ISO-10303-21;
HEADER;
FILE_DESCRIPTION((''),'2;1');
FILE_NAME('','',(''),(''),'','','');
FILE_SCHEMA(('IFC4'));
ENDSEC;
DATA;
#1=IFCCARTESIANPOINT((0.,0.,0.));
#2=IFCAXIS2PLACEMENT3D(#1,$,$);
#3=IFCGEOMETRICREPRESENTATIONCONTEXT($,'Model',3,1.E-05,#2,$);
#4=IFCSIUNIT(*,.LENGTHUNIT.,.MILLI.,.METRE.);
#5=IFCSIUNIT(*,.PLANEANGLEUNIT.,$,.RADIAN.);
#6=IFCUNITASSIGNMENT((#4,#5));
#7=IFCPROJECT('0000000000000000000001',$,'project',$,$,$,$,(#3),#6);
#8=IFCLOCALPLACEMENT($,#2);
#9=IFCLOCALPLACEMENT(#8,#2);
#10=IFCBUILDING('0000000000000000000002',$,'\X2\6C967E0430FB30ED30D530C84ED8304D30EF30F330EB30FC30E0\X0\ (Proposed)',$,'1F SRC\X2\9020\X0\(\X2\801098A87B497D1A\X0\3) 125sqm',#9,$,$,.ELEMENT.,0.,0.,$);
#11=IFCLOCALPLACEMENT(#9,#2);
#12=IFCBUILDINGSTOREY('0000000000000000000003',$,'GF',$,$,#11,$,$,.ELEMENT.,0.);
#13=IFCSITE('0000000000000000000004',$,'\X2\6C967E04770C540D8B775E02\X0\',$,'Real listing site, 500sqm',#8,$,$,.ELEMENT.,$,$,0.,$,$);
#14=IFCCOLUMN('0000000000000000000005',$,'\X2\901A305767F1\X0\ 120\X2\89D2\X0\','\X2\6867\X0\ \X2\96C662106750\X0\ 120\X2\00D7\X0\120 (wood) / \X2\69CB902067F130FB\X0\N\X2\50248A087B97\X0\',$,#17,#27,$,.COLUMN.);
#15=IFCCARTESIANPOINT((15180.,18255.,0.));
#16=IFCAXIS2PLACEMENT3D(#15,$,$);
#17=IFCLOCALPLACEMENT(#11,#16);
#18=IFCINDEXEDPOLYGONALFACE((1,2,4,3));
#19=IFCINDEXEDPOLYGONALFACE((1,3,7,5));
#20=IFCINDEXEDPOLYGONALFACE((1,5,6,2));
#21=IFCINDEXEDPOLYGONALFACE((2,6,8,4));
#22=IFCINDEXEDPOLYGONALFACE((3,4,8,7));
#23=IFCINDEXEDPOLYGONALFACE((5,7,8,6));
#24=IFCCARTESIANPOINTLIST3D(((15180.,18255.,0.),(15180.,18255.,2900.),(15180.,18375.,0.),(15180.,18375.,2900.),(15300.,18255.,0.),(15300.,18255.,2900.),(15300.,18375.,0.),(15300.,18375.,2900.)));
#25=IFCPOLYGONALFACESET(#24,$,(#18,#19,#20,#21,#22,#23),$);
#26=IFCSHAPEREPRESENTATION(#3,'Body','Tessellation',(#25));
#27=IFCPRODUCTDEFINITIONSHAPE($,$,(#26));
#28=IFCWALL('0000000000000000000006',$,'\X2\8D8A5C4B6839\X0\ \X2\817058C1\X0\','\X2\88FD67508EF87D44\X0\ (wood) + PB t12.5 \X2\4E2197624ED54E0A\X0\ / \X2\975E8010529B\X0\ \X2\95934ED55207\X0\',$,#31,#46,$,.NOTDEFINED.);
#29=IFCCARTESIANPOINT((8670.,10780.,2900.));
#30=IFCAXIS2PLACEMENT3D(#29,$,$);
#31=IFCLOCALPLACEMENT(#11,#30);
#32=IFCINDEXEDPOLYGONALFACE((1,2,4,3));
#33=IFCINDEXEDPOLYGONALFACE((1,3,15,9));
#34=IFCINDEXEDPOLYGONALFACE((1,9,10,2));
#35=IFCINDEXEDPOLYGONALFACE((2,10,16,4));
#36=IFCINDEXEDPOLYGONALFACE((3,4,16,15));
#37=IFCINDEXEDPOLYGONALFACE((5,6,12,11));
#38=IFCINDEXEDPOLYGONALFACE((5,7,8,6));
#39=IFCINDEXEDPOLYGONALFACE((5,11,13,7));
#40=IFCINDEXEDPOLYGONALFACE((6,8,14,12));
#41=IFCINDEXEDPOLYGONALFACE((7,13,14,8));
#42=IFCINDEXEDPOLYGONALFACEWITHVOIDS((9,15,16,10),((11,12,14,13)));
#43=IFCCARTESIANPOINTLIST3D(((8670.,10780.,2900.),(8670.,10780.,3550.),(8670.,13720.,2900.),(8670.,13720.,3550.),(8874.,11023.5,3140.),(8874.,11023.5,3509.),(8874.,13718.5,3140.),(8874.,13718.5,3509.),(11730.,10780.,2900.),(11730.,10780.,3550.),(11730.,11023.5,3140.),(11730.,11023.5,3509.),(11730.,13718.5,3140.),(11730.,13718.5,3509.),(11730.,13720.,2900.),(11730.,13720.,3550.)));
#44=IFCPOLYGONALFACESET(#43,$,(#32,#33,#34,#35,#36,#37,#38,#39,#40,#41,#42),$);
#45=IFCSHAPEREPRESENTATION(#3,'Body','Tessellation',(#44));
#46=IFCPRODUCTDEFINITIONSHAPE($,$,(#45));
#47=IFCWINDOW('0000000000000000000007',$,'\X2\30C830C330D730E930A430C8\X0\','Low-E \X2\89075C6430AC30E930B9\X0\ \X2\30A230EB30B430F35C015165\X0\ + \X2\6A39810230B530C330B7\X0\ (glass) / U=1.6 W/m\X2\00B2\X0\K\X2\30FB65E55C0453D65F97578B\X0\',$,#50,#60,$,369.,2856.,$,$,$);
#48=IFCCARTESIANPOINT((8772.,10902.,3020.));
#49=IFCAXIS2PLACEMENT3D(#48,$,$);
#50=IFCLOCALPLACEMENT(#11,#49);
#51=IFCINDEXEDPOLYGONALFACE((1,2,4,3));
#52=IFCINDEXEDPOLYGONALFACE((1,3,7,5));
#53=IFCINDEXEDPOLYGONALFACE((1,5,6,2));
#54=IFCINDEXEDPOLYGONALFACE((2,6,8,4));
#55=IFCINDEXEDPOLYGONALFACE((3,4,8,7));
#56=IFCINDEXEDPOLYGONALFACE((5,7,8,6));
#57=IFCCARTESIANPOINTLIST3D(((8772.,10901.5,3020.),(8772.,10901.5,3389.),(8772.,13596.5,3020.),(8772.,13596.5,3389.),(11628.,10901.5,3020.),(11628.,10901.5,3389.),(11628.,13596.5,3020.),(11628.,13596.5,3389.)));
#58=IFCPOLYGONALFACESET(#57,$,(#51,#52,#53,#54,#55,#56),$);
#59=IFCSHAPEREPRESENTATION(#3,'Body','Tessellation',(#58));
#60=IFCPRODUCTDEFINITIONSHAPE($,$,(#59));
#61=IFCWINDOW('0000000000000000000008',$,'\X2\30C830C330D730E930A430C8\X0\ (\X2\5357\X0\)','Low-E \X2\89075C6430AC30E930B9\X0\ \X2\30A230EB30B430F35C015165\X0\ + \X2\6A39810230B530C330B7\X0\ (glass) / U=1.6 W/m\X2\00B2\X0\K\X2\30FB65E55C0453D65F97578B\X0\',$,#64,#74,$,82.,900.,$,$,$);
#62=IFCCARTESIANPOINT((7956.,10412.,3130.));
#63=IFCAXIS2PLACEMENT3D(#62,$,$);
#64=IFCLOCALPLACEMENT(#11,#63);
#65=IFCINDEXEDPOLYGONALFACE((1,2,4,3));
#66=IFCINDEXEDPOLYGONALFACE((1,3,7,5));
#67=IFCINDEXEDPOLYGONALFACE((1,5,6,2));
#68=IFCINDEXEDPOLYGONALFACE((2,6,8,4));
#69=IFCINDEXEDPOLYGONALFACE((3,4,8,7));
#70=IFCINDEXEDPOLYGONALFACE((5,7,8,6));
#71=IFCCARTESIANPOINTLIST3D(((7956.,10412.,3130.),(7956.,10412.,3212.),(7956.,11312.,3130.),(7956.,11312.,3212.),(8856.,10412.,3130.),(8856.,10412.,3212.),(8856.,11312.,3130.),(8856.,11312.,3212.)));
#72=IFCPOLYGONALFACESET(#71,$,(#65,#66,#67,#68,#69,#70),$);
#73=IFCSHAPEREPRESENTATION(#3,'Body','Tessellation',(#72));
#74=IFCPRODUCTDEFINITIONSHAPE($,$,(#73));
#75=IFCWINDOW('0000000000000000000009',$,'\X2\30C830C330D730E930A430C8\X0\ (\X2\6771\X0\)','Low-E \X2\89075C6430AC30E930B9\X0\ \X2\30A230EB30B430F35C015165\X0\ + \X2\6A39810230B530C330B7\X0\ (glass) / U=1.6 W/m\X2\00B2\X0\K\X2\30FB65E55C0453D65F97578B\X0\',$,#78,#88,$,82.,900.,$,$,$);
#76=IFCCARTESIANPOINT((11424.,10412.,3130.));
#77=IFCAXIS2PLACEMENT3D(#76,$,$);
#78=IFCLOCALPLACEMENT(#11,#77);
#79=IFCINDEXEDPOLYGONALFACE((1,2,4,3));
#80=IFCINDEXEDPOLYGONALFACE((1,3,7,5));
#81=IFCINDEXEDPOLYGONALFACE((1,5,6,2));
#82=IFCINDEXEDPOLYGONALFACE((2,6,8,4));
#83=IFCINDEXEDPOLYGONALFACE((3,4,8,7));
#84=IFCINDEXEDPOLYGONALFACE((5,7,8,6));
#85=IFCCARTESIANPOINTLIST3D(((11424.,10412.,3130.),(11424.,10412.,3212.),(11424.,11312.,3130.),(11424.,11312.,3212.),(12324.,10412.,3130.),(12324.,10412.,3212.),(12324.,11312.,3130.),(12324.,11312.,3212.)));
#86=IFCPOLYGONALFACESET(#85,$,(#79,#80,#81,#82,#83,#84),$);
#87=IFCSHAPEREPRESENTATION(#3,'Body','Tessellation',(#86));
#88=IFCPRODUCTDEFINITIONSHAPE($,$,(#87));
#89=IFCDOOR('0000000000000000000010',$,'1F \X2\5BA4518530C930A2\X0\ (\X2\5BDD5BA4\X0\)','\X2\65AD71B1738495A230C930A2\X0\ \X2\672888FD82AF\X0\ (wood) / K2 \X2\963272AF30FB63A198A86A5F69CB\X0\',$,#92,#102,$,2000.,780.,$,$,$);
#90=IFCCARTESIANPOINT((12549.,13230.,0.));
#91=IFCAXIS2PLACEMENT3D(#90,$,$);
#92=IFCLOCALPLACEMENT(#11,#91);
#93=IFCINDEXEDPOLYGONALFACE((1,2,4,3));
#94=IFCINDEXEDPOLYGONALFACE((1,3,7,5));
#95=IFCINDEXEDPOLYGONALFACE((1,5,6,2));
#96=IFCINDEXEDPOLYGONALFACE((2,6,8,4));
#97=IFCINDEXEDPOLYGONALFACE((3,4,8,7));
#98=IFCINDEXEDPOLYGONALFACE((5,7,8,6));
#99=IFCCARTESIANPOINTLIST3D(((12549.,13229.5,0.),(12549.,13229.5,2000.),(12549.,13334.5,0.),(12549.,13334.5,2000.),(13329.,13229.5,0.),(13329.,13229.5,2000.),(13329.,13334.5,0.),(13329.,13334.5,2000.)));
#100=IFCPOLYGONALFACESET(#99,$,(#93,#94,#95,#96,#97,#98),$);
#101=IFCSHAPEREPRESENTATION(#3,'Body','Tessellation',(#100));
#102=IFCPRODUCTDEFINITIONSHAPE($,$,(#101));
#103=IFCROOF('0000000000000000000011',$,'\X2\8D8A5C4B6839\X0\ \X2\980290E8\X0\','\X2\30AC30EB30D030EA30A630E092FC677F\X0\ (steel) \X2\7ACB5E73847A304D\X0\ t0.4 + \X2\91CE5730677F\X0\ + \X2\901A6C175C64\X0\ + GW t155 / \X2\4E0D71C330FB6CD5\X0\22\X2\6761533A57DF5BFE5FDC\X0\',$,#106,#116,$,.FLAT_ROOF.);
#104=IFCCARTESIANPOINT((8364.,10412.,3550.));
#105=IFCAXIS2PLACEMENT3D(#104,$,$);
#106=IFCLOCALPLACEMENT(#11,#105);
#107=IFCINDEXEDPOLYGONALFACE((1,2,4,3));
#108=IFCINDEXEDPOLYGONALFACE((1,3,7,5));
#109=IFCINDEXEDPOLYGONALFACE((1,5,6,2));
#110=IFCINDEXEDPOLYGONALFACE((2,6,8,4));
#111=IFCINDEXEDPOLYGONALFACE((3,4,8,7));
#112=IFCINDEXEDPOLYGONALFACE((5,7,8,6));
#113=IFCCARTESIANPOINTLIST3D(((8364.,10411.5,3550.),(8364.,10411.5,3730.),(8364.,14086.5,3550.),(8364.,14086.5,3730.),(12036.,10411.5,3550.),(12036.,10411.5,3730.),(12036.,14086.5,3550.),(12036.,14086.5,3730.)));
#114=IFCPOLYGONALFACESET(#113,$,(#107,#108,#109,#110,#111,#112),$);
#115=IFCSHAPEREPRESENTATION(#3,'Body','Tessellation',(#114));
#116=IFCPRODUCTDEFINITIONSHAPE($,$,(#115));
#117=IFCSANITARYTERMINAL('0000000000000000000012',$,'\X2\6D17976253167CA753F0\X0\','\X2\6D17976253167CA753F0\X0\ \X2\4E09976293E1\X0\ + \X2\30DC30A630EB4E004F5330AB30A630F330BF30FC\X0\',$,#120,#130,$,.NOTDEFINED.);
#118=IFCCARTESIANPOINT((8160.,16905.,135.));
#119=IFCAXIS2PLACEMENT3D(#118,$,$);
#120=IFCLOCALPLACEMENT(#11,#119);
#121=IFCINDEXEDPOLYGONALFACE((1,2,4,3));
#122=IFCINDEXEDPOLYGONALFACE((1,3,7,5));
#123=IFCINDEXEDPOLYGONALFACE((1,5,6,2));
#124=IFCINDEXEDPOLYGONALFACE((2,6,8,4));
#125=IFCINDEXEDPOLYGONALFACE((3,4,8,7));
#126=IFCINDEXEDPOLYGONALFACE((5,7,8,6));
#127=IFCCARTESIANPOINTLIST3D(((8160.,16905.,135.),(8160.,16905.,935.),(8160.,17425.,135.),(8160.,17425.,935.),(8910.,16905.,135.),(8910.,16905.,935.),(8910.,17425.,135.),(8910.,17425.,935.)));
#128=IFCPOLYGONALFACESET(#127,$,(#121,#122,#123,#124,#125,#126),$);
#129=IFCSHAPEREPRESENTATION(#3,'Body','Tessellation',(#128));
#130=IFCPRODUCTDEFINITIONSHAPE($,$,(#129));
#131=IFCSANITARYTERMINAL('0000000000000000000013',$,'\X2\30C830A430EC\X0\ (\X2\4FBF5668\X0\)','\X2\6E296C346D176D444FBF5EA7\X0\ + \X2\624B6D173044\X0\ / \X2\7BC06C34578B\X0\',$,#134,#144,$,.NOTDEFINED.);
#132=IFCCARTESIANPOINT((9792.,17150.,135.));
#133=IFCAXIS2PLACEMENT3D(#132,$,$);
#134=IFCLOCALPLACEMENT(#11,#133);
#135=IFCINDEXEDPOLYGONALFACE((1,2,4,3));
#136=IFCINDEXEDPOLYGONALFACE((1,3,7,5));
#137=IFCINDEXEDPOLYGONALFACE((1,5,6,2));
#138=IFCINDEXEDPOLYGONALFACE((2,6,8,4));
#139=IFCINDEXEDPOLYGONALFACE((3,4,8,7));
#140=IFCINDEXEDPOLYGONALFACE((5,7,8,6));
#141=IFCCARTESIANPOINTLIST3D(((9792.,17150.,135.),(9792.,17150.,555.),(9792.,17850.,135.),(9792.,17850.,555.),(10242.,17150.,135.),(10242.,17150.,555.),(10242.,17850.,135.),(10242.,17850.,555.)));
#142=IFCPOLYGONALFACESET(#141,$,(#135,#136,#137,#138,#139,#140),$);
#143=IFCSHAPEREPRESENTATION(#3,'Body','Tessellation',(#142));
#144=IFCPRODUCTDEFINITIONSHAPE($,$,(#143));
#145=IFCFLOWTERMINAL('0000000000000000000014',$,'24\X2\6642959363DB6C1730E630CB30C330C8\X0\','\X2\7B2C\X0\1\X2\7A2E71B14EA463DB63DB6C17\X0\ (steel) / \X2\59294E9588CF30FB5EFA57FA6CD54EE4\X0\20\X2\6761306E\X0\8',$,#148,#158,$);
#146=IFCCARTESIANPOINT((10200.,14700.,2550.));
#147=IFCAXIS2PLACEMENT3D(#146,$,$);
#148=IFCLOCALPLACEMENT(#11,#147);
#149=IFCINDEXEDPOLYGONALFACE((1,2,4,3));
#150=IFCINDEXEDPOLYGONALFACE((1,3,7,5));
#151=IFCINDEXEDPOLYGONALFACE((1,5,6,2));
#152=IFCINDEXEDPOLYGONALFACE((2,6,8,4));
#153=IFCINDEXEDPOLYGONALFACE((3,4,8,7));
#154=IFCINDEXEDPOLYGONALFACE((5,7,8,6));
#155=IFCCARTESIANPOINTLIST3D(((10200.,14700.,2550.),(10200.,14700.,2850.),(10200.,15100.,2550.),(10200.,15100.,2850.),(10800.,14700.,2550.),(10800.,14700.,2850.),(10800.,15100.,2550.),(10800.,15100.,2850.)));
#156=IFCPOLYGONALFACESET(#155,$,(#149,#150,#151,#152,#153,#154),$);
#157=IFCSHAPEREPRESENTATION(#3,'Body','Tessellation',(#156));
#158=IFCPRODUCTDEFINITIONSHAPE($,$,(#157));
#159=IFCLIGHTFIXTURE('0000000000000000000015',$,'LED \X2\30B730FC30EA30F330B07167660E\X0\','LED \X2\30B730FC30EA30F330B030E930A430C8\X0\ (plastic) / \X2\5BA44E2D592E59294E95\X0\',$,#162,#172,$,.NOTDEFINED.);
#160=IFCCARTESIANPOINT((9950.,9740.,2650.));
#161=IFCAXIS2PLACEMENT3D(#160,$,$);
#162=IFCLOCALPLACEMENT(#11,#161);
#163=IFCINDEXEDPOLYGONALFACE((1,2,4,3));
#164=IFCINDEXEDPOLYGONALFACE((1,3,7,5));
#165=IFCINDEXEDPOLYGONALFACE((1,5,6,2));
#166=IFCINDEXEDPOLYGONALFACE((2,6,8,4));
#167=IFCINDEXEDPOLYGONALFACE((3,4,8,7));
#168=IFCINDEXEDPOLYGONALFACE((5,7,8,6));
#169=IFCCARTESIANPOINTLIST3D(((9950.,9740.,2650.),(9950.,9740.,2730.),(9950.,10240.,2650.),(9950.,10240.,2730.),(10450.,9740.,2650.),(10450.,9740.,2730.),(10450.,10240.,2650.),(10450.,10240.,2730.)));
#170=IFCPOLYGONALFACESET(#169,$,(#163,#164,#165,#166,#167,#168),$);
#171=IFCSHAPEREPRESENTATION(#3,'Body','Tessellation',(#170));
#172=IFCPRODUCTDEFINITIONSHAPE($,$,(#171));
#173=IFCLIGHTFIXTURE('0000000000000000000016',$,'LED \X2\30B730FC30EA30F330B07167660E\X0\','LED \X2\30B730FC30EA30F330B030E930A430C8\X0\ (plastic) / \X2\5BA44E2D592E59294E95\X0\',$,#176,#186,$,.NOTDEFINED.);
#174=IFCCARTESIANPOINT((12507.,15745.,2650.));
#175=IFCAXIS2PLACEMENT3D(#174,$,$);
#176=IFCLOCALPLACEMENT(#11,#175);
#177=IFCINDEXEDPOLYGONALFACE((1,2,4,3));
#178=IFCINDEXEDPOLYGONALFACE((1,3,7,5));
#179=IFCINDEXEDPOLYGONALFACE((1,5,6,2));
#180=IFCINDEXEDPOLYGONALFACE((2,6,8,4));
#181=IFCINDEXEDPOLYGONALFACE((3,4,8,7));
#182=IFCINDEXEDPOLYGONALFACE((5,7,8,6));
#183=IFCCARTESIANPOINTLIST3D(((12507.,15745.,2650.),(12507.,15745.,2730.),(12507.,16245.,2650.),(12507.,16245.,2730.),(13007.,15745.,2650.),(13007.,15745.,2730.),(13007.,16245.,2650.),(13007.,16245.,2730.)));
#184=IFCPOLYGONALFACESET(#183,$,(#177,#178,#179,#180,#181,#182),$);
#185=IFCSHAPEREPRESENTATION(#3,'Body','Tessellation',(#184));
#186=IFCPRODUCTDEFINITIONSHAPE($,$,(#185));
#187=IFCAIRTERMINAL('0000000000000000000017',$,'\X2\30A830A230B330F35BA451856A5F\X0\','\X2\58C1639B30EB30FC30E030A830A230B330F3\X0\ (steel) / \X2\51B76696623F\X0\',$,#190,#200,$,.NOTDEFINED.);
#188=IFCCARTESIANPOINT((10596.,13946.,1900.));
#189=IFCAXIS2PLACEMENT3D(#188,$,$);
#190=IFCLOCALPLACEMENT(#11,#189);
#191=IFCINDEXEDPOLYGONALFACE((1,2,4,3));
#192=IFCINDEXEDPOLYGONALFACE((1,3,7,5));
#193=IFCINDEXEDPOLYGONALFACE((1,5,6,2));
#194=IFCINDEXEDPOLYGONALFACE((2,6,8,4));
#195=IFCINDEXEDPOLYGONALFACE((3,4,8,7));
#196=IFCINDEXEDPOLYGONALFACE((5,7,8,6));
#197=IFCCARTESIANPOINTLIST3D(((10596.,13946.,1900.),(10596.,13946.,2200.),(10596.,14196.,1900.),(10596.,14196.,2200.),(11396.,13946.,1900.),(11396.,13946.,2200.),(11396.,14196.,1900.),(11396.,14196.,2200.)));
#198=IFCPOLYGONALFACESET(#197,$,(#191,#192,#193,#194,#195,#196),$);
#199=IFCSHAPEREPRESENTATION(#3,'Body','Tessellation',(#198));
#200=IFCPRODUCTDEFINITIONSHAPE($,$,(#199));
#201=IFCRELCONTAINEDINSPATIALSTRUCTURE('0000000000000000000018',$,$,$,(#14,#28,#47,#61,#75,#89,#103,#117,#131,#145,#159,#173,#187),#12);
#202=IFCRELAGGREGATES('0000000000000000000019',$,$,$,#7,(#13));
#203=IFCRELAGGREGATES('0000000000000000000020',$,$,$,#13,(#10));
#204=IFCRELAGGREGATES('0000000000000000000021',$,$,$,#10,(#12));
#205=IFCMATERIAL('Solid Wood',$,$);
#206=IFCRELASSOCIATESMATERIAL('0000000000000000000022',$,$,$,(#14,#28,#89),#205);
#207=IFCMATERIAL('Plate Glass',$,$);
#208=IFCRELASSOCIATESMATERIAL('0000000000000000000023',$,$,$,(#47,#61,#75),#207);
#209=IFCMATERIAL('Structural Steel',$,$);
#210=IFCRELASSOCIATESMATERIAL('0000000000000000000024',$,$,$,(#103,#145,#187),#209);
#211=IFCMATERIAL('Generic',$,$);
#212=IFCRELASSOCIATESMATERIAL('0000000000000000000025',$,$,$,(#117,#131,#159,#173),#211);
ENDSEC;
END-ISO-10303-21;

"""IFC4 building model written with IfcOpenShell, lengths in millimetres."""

from ifc_helpers import new_model, si_unit, frame, frame_2d, origin, place, context, project, spatial, rectangle, extrude, material, element, fill, save


model = new_model("IFC4")

# Units and contexts
model_context = context("Model", 3, precision=1e-05, world=origin())
ifc_project = project(units=[si_unit("LENGTHUNIT", "METRE", prefix="MILLI"), si_unit("PLANEANGLEUNIT", "RADIAN")], contexts=[model_context])

# Site, building, storey
site_placement = place(None, origin())
site = spatial("IfcSite", under=ifc_project, at=site_placement, Name="沖縄県名護市", ObjectType="Real listing site, 500sqm", CompositionType="ELEMENT", RefElevation=0.0)
building_placement = place(site_placement, origin())
building = spatial("IfcBuilding", under=site, at=building_placement, Name="沖縄・ロフト付きワンルーム (Proposed)", ObjectType="1F SRC造(耐風等級3) 125sqm", CompositionType="ELEMENT", ElevationOfRefHeight=0.0, ElevationOfTerrain=0.0)
storey_placement = place(building_placement, origin())
storey = spatial("IfcBuildingStorey", under=building, at=storey_placement, Name="GF", CompositionType="ELEMENT", Elevation=0.0)

# Column
ifc_material_1 = material(Name="Solid Wood")
column_1_placement = place(storey_placement, frame((15180.0, 18255.0, 0.0)))
element("IfcColumn", 1, at=column_1_placement, inside=storey, material=ifc_material_1, Name="通し柱 120角", Description="桧 集成材 120×120 (wood) / 構造柱・N値計算", PredefinedType="COLUMN", context=model_context, shape_type="SweptSolid", body=[
    extrude(rectangle(XDim=120.0, YDim=120.0, at=frame_2d((60.0, 60.0))), frame((15180.0, 18255.0, 0.0)), (0.0, 0.0, 1.0), 2900.0),
])

# Wall, openings, windows
wall_1_placement = place(storey_placement, frame((8670.0, 10780.0, 2900.0)))
wall_1 = element("IfcWall", 2, at=wall_1_placement, inside=storey, material=ifc_material_1, Name="越屋根 腰壁", Description="製材軸組 (wood) + PB t12.5 両面仕上 / 非耐力 間仕切", PredefinedType="NOTDEFINED", context=model_context, shape_type="SweptSolid", body=[
    extrude(rectangle(XDim=3060.0, YDim=2940.0, at=frame_2d((1530.0, 1470.0))), frame((8670.0, 10780.0, 2900.0)), (0.0, 0.0, 1.0), 650.0),
])
opening_1_placement = place(storey_placement, frame((8772.0, 10902.0, 3020.0)))
opening_1 = element("IfcOpeningElement", 3, at=opening_1_placement, cuts=wall_1, PredefinedType="NOTDEFINED", context=model_context, shape_type="SweptSolid", body=[
    extrude(rectangle(XDim=2856.0, YDim=2695.0, at=frame_2d((1428.0, 1347.0))), frame((8772.0, 10902.0, 3020.0)), (0.0, 0.0, 1.0), 369.0),
])
opening_2_placement = place(storey_placement, frame((7956.0, 10412.0, 3130.0)))
opening_2 = element("IfcOpeningElement", 4, at=opening_2_placement, cuts=wall_1, PredefinedType="NOTDEFINED", context=model_context, shape_type="SweptSolid", body=[
    extrude(rectangle(XDim=900.0, YDim=900.0, at=frame_2d((450.0, 450.0))), frame((7956.0, 10412.0, 3130.0)), (0.0, 0.0, 1.0), 82.0),
])
opening_3_placement = place(storey_placement, frame((11424.0, 10412.0, 3130.0)))
opening_3 = element("IfcOpeningElement", 5, at=opening_3_placement, cuts=wall_1, PredefinedType="NOTDEFINED", context=model_context, shape_type="SweptSolid", body=[
    extrude(rectangle(XDim=900.0, YDim=900.0, at=frame_2d((450.0, 450.0))), frame((11424.0, 10412.0, 3130.0)), (0.0, 0.0, 1.0), 82.0),
])
ifc_material_2 = material(Name="Plate Glass")
window_1_placement = place(storey_placement, frame((8772.0, 10902.0, 3020.0)))
window_1 = element("IfcWindow", 6, at=window_1_placement, inside=storey, material=ifc_material_2, Name="トップライト", Description="Low-E 複層ガラス アルゴン封入 + 樹脂サッシ (glass) / U=1.6 W/m²K・日射取得型", OverallHeight=369.0, OverallWidth=2856.0, context=model_context, shape_type="SweptSolid", body=[
    extrude(rectangle(XDim=2856.0, YDim=2695.0, at=frame_2d((1428.0, 1347.0))), frame((8772.0, 10902.0, 3020.0)), (0.0, 0.0, 1.0), 369.0),
])
fill(opening_1, window_1)
window_2_placement = place(storey_placement, frame((7956.0, 10412.0, 3130.0)))
window_2 = element("IfcWindow", 7, at=window_2_placement, inside=storey, material=ifc_material_2, Name="トップライト (南)", Description="Low-E 複層ガラス アルゴン封入 + 樹脂サッシ (glass) / U=1.6 W/m²K・日射取得型", OverallHeight=82.0, OverallWidth=900.0, context=model_context, shape_type="SweptSolid", body=[
    extrude(rectangle(XDim=900.0, YDim=900.0, at=frame_2d((450.0, 450.0))), frame((7956.0, 10412.0, 3130.0)), (0.0, 0.0, 1.0), 82.0),
])
fill(opening_2, window_2)
window_3_placement = place(storey_placement, frame((11424.0, 10412.0, 3130.0)))
window_3 = element("IfcWindow", 8, at=window_3_placement, inside=storey, material=ifc_material_2, Name="トップライト (東)", Description="Low-E 複層ガラス アルゴン封入 + 樹脂サッシ (glass) / U=1.6 W/m²K・日射取得型", OverallHeight=82.0, OverallWidth=900.0, context=model_context, shape_type="SweptSolid", body=[
    extrude(rectangle(XDim=900.0, YDim=900.0, at=frame_2d((450.0, 450.0))), frame((11424.0, 10412.0, 3130.0)), (0.0, 0.0, 1.0), 82.0),
])
fill(opening_3, window_3)

# Door
door_placement = place(storey_placement, frame((12549.0, 13230.0, 0.0)))
element("IfcDoor", 9, at=door_placement, inside=storey, material=ifc_material_1, Name="1F 室内ドア (寝室)", Description="断熱玄関ドア 木製芯 (wood) / K2 防犯・採風機構", OverallHeight=2000.0, OverallWidth=780.0, context=model_context, shape_type="SweptSolid", body=[
    extrude(rectangle(XDim=780.0, YDim=105.0, at=frame_2d((390.0, 52.0))), frame((12549.0, 13230.0, 0.0)), (0.0, 0.0, 1.0), 2000.0),
])

# Roof
ifc_material_3 = material(Name="Structural Steel")
roof_placement = place(storey_placement, frame((8364.0, 10412.0, 3550.0)))
element("IfcRoof", 10, at=roof_placement, inside=storey, material=ifc_material_3, Name="越屋根 頂部", Description="ガルバリウム鋼板 (steel) 立平葺き t0.4 + 野地板 + 通気層 + GW t155 / 不燃・法22条区域対応", PredefinedType="FLAT_ROOF", context=model_context, shape_type="SweptSolid", body=[
    extrude(rectangle(XDim=3672.0, YDim=3675.0, at=frame_2d((1836.0, 1837.0))), frame((8364.0, 10412.0, 3550.0)), (0.0, 0.0, 1.0), 180.0),
])

# Sanitary terminals
ifc_material_4 = material(Name="Generic")
sanitary_terminal_1_placement = place(storey_placement, frame((8160.0, 16905.0, 135.0)))
element("IfcSanitaryTerminal", 11, at=sanitary_terminal_1_placement, inside=storey, material=ifc_material_4, Name="洗面化粧台", Description="洗面化粧台 三面鏡 + ボウル一体カウンター", PredefinedType="NOTDEFINED", context=model_context, shape_type="SweptSolid", body=[
    extrude(rectangle(XDim=750.0, YDim=520.0, at=frame_2d((375.0, 260.0))), frame((8160.0, 16905.0, 135.0)), (0.0, 0.0, 1.0), 800.0),
])
sanitary_terminal_2_placement = place(storey_placement, frame((9792.0, 17150.0, 135.0)))
element("IfcSanitaryTerminal", 12, at=sanitary_terminal_2_placement, inside=storey, material=ifc_material_4, Name="トイレ (便器)", Description="温水洗浄便座 + 手洗い / 節水型", PredefinedType="NOTDEFINED", context=model_context, shape_type="SweptSolid", body=[
    extrude(rectangle(XDim=450.0, YDim=700.0, at=frame_2d((225.0, 350.0))), frame((9792.0, 17150.0, 135.0)), (0.0, 0.0, 1.0), 420.0),
])

# Flow terminal
flow_terminal_placement = place(storey_placement, frame((10200.0, 14700.0, 2550.0)))
element("IfcFlowTerminal", 13, at=flow_terminal_placement, inside=storey, material=ifc_material_3, Name="24時間換気ユニット", Description="第1種熱交換換気 (steel) / 天井裏・建基法令20条の8", context=model_context, shape_type="SweptSolid", body=[
    extrude(rectangle(XDim=600.0, YDim=400.0, at=frame_2d((300.0, 200.0))), frame((10200.0, 14700.0, 2550.0)), (0.0, 0.0, 1.0), 300.0),
])

# Light fixtures
light_fixture_1_placement = place(storey_placement, frame((9950.0, 9740.0, 2650.0)))
element("IfcLightFixture", 14, at=light_fixture_1_placement, inside=storey, material=ifc_material_4, Name="LED シーリング照明", Description="LED シーリングライト (plastic) / 室中央天井", PredefinedType="NOTDEFINED", context=model_context, shape_type="SweptSolid", body=[
    extrude(rectangle(XDim=500.0, YDim=500.0, at=frame_2d((250.0, 250.0))), frame((9950.0, 9740.0, 2650.0)), (0.0, 0.0, 1.0), 80.0),
])
light_fixture_2_placement = place(storey_placement, frame((12507.0, 15745.0, 2650.0)))
element("IfcLightFixture", 15, at=light_fixture_2_placement, inside=storey, material=ifc_material_4, Name="LED シーリング照明", Description="LED シーリングライト (plastic) / 室中央天井", PredefinedType="NOTDEFINED", context=model_context, shape_type="SweptSolid", body=[
    extrude(rectangle(XDim=500.0, YDim=500.0, at=frame_2d((250.0, 250.0))), frame((12507.0, 15745.0, 2650.0)), (0.0, 0.0, 1.0), 80.0),
])

# Air terminal
air_terminal_placement = place(storey_placement, frame((10596.0, 13946.0, 1900.0)))
element("IfcAirTerminal", 16, at=air_terminal_placement, inside=storey, material=ifc_material_3, Name="エアコン室内機", Description="壁掛ルームエアコン (steel) / 冷暖房", PredefinedType="NOTDEFINED", context=model_context, shape_type="SweptSolid", body=[
    extrude(rectangle(XDim=800.0, YDim=250.0, at=frame_2d((400.0, 125.0))), frame((10596.0, 13946.0, 1900.0)), (0.0, 0.0, 1.0), 300.0),
])

save(model, "model.ifc")
